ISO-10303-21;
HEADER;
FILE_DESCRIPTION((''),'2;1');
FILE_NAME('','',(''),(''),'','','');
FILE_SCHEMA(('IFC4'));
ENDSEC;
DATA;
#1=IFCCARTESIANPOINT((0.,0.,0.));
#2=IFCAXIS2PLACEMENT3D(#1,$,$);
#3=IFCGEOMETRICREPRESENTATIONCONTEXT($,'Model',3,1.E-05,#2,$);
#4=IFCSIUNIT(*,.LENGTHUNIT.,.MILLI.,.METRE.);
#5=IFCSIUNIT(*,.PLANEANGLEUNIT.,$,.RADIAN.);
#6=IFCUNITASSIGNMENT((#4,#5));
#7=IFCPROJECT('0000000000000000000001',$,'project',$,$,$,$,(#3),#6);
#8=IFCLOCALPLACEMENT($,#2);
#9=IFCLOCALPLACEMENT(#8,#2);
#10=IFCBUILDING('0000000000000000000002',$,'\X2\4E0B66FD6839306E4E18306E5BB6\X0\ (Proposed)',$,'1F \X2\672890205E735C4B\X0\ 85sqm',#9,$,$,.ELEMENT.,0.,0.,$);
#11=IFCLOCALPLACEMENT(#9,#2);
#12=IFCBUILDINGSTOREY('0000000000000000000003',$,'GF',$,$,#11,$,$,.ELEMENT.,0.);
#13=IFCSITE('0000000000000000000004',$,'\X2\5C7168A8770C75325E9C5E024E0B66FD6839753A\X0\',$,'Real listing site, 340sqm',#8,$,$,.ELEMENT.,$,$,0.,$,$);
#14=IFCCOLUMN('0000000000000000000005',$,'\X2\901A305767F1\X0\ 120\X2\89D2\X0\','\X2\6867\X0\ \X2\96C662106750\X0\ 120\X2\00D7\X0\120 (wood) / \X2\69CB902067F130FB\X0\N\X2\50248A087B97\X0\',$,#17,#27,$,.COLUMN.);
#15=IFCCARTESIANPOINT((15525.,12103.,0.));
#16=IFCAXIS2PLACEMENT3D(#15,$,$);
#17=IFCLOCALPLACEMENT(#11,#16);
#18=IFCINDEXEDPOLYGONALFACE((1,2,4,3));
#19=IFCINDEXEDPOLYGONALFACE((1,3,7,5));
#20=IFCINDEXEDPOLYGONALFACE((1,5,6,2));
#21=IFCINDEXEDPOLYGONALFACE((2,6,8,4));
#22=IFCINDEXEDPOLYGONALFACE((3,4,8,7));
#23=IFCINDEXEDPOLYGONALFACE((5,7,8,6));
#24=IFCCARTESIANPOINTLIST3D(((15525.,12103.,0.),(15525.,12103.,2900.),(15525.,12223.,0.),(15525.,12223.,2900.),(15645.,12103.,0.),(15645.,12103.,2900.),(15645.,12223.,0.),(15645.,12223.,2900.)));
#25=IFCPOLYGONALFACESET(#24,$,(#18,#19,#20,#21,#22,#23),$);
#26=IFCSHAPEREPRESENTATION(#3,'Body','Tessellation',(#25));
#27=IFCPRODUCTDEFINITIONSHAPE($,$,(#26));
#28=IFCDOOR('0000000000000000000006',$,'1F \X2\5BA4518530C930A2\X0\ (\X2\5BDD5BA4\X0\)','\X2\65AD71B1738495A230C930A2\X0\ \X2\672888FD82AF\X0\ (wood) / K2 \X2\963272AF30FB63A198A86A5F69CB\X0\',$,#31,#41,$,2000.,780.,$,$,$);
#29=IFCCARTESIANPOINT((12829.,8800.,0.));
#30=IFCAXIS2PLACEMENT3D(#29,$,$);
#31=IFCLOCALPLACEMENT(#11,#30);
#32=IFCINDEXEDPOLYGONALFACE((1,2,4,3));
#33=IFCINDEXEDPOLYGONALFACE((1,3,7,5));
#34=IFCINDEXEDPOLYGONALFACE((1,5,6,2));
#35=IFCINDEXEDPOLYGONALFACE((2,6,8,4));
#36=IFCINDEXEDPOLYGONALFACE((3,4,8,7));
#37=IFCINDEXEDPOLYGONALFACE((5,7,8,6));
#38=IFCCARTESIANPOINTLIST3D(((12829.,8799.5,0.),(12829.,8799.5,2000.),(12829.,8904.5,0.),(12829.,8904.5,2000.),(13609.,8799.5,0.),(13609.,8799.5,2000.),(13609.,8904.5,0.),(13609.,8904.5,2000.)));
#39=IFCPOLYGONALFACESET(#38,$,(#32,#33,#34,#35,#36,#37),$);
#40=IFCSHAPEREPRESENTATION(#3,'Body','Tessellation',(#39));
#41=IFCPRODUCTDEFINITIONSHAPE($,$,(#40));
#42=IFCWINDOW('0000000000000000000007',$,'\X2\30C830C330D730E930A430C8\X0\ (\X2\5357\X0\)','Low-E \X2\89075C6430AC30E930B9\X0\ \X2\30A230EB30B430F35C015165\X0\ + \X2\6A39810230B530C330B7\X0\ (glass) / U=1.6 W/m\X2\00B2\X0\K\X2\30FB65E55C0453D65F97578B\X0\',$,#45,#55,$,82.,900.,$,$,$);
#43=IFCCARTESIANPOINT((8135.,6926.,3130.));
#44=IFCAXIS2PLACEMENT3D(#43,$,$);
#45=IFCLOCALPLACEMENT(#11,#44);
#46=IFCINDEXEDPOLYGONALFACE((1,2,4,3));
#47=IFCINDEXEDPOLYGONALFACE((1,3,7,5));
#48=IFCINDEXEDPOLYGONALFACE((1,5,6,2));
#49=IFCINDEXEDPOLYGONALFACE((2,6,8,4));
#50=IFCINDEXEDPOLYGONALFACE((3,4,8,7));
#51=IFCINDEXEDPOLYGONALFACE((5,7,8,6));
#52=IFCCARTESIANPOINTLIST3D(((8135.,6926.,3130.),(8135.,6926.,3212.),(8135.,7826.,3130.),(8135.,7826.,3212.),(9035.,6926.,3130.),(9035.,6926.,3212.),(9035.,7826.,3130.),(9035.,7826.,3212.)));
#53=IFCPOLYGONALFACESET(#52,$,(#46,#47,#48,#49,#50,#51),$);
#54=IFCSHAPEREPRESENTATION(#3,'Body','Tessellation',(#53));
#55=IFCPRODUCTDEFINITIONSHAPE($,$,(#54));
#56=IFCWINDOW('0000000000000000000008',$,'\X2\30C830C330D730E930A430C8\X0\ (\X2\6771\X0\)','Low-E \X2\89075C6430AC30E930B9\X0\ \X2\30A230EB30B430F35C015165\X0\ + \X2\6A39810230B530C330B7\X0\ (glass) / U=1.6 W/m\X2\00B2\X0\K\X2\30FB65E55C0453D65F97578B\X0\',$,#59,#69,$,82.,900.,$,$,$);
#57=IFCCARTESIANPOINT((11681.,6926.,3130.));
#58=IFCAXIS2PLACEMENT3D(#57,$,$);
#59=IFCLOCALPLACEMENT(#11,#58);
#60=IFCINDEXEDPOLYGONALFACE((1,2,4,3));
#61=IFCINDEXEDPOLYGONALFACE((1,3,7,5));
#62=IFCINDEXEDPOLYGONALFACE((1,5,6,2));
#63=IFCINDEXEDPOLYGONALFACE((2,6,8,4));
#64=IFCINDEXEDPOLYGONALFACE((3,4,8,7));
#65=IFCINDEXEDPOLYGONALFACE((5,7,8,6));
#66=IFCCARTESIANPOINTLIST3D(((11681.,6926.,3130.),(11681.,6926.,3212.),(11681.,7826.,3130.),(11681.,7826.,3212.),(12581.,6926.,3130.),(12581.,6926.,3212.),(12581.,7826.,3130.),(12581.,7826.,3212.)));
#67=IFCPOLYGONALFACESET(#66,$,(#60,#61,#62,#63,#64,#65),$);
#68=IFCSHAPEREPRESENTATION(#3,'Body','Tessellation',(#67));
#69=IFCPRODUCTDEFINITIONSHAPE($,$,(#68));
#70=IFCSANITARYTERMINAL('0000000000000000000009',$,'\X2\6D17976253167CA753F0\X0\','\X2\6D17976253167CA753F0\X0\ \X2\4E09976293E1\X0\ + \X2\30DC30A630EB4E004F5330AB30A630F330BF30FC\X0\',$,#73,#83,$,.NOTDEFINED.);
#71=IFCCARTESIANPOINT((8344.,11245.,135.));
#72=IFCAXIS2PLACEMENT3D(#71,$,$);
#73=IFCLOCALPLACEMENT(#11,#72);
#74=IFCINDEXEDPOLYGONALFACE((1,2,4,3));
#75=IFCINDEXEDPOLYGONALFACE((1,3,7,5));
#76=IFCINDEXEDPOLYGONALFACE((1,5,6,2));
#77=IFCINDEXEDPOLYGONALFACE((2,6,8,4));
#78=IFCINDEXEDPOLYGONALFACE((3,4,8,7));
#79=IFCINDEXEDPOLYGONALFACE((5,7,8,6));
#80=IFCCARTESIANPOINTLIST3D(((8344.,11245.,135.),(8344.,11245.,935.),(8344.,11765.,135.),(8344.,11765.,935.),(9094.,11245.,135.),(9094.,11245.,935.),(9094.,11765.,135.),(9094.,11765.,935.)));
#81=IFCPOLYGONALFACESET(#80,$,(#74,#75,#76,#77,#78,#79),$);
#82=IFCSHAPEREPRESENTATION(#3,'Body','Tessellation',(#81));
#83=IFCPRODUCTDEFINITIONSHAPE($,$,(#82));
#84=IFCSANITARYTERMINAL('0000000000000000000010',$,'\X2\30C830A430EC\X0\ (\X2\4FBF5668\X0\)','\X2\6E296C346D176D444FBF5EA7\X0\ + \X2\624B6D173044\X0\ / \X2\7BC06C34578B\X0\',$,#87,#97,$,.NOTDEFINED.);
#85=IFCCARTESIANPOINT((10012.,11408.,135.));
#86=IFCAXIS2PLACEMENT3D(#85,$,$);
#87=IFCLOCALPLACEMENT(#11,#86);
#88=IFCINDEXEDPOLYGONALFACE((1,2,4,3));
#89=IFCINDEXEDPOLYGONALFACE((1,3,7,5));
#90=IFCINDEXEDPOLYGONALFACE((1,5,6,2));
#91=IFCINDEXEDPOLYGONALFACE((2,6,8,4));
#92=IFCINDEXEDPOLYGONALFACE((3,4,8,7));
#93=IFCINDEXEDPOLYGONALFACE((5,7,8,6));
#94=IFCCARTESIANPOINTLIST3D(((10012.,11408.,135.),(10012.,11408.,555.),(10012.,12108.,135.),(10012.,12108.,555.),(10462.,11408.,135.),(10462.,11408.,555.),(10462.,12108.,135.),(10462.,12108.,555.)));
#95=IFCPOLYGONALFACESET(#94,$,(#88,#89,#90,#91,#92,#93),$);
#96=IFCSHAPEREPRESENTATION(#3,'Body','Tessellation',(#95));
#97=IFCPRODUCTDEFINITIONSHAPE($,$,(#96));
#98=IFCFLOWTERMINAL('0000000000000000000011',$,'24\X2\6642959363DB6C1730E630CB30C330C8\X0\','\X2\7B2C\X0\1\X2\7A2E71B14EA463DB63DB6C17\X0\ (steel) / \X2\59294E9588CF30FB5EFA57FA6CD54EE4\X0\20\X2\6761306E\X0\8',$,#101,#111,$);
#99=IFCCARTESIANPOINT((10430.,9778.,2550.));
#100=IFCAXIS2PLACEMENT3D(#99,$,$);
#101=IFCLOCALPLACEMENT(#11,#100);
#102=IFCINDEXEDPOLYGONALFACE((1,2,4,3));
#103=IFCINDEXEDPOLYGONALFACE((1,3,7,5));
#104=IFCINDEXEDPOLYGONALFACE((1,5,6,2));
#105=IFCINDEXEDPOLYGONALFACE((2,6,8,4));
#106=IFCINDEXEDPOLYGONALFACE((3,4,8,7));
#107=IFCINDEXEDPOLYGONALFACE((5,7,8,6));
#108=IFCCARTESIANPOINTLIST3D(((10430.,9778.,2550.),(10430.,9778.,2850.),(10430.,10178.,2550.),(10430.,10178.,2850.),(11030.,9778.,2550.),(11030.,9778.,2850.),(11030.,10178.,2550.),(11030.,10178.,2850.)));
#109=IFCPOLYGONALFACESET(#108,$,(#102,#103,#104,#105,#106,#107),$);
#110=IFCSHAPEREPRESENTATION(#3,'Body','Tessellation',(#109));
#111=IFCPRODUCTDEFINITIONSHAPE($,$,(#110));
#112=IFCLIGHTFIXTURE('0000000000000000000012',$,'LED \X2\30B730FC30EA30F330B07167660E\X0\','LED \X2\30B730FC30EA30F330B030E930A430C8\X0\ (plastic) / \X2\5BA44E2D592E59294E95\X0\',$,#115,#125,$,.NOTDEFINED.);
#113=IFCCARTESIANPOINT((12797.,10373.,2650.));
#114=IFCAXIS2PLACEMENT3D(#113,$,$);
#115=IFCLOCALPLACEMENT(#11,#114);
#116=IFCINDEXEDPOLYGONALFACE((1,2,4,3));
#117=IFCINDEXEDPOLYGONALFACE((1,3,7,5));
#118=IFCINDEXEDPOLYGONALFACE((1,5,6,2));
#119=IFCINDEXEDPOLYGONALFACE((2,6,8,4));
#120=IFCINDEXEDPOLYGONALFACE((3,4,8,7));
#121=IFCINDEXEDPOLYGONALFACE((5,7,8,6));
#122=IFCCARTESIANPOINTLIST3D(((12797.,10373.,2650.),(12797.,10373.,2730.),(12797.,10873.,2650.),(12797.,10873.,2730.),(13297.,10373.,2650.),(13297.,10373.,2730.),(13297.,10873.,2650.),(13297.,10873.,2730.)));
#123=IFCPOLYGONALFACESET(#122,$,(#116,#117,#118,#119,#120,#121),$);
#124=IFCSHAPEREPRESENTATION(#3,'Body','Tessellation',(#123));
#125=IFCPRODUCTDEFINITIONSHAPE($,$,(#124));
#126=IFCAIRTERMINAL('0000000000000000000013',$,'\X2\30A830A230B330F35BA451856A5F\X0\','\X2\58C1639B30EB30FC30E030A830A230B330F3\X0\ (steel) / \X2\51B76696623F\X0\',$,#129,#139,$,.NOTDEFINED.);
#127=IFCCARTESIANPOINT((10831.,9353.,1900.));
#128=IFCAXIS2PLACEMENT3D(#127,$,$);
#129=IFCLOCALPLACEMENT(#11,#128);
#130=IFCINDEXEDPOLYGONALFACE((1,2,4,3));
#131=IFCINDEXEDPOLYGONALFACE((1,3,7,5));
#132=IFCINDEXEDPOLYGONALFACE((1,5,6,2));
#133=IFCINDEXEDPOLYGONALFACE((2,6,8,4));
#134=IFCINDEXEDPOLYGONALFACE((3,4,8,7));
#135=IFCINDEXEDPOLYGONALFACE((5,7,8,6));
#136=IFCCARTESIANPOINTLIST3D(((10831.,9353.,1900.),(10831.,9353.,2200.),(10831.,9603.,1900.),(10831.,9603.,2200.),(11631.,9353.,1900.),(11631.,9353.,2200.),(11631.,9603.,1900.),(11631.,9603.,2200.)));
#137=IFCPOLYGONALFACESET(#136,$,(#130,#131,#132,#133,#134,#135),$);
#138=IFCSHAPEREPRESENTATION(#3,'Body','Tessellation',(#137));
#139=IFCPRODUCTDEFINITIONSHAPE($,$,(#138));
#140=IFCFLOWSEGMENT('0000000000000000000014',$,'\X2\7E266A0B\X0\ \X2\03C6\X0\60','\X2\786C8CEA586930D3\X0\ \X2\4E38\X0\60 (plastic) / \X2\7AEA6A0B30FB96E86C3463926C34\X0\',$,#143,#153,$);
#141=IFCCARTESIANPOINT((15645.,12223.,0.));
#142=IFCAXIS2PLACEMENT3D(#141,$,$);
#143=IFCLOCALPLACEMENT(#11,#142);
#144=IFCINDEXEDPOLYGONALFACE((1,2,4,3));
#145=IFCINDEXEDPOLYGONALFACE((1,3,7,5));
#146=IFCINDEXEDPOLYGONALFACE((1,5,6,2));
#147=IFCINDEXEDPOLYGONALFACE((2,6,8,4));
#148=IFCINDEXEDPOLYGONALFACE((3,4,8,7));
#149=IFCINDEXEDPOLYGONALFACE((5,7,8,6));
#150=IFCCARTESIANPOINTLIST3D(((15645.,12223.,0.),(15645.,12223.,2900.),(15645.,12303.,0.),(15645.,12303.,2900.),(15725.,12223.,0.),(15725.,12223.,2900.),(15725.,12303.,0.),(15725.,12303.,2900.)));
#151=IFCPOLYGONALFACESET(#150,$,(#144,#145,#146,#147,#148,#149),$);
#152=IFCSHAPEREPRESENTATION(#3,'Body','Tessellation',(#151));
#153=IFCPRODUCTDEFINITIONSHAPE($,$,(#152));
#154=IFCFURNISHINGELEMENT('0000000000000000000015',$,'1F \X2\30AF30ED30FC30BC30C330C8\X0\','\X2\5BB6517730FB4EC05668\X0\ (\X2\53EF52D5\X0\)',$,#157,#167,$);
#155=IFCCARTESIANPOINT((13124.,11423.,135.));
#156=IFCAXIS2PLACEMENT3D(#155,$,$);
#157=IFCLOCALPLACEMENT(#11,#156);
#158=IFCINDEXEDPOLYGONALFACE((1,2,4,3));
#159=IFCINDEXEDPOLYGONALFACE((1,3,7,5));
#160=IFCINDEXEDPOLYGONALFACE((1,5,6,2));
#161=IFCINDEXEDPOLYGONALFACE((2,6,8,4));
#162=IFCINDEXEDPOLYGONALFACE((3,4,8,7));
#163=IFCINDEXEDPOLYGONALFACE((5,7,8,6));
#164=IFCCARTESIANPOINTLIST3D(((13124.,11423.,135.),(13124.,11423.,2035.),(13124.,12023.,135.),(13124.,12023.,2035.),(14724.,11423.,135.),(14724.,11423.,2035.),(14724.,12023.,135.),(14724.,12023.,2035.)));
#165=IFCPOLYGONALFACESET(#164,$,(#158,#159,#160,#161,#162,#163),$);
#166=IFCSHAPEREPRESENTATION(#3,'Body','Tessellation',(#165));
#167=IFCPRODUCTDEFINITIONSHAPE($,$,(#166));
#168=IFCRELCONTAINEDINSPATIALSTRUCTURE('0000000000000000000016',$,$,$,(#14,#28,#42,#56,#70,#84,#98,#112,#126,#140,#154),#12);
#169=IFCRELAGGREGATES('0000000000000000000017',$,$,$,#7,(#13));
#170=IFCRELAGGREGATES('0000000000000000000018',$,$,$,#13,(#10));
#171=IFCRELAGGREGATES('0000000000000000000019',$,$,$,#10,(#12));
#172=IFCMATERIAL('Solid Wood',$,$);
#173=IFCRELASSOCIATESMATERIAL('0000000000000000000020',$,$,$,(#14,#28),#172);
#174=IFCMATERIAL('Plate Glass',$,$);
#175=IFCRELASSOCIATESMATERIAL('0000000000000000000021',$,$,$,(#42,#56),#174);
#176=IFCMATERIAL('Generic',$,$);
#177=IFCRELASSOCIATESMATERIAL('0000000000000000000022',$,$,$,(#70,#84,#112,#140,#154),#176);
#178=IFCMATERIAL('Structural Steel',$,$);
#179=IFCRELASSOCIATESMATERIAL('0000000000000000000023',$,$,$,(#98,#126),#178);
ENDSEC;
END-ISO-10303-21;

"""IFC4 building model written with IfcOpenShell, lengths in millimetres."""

from ifc_helpers import new_model, si_unit, frame, frame_2d, origin, place, context, project, spatial, rectangle, extrude, material, element, save


model = new_model("IFC4")

# Units and contexts
model_context = context("Model", 3, precision=1e-05, world=origin())
ifc_project = project(units=[si_unit("LENGTHUNIT", "METRE", prefix="MILLI"), si_unit("PLANEANGLEUNIT", "RADIAN")], contexts=[model_context])

# Site, building, storey
site_placement = place(None, origin())
site = spatial("IfcSite", under=ifc_project, at=site_placement, Name="山梨県甲府市下曽根町", ObjectType="Real listing site, 340sqm", CompositionType="ELEMENT", RefElevation=0.0)
building_placement = place(site_placement, origin())
building = spatial("IfcBuilding", under=site, at=building_placement, Name="下曽根の丘の家 (Proposed)", ObjectType="1F 木造平屋 85sqm", CompositionType="ELEMENT", ElevationOfRefHeight=0.0, ElevationOfTerrain=0.0)
storey_placement = place(building_placement, origin())
storey = spatial("IfcBuildingStorey", under=building, at=storey_placement, Name="GF", CompositionType="ELEMENT", Elevation=0.0)

# Column
ifc_material_1 = material(Name="Solid Wood")
column_1_placement = place(storey_placement, frame((15525.0, 12103.0, 0.0)))
element("IfcColumn", 1, at=column_1_placement, inside=storey, material=ifc_material_1, Name="通し柱 120角", Description="桧 集成材 120×120 (wood) / 構造柱・N値計算", PredefinedType="COLUMN", context=model_context, shape_type="SweptSolid", body=[
    extrude(rectangle(XDim=120.0, YDim=120.0, at=frame_2d((60.0, 60.0))), frame((15525.0, 12103.0, 0.0)), (0.0, 0.0, 1.0), 2900.0),
])

# Door
door_placement = place(storey_placement, frame((12829.0, 8800.0, 0.0)))
element("IfcDoor", 2, at=door_placement, inside=storey, material=ifc_material_1, Name="1F 室内ドア (寝室)", Description="断熱玄関ドア 木製芯 (wood) / K2 防犯・採風機構", OverallHeight=2000.0, OverallWidth=780.0, context=model_context, shape_type="SweptSolid", body=[
    extrude(rectangle(XDim=780.0, YDim=105.0, at=frame_2d((390.0, 52.0))), frame((12829.0, 8800.0, 0.0)), (0.0, 0.0, 1.0), 2000.0),
])

# Windows
ifc_material_2 = material(Name="Plate Glass")
window_1_placement = place(storey_placement, frame((8135.0, 6926.0, 3130.0)))
element("IfcWindow", 3, at=window_1_placement, inside=storey, material=ifc_material_2, Name="トップライト (南)", Description="Low-E 複層ガラス アルゴン封入 + 樹脂サッシ (glass) / U=1.6 W/m²K・日射取得型", OverallHeight=82.0, OverallWidth=900.0, context=model_context, shape_type="SweptSolid", body=[
    extrude(rectangle(XDim=900.0, YDim=900.0, at=frame_2d((450.0, 450.0))), frame((8135.0, 6926.0, 3130.0)), (0.0, 0.0, 1.0), 82.0),
])
window_2_placement = place(storey_placement, frame((11681.0, 6926.0, 3130.0)))
element("IfcWindow", 4, at=window_2_placement, inside=storey, material=ifc_material_2, Name="トップライト (東)", Description="Low-E 複層ガラス アルゴン封入 + 樹脂サッシ (glass) / U=1.6 W/m²K・日射取得型", OverallHeight=82.0, OverallWidth=900.0, context=model_context, shape_type="SweptSolid", body=[
    extrude(rectangle(XDim=900.0, YDim=900.0, at=frame_2d((450.0, 450.0))), frame((11681.0, 6926.0, 3130.0)), (0.0, 0.0, 1.0), 82.0),
])

# Sanitary terminals
ifc_material_3 = material(Name="Generic")
sanitary_terminal_1_placement = place(storey_placement, frame((8344.0, 11245.0, 135.0)))
element("IfcSanitaryTerminal", 5, at=sanitary_terminal_1_placement, inside=storey, material=ifc_material_3, Name="洗面化粧台", Description="洗面化粧台 三面鏡 + ボウル一体カウンター", PredefinedType="NOTDEFINED", context=model_context, shape_type="SweptSolid", body=[
    extrude(rectangle(XDim=750.0, YDim=520.0, at=frame_2d((375.0, 260.0))), frame((8344.0, 11245.0, 135.0)), (0.0, 0.0, 1.0), 800.0),
])
sanitary_terminal_2_placement = place(storey_placement, frame((10012.0, 11408.0, 135.0)))
element("IfcSanitaryTerminal", 6, at=sanitary_terminal_2_placement, inside=storey, material=ifc_material_3, Name="トイレ (便器)", Description="温水洗浄便座 + 手洗い / 節水型", PredefinedType="NOTDEFINED", context=model_context, shape_type="SweptSolid", body=[
    extrude(rectangle(XDim=450.0, YDim=700.0, at=frame_2d((225.0, 350.0))), frame((10012.0, 11408.0, 135.0)), (0.0, 0.0, 1.0), 420.0),
])

# Flow terminal
ifc_material_4 = material(Name="Structural Steel")
flow_terminal_placement = place(storey_placement, frame((10430.0, 9778.0, 2550.0)))
element("IfcFlowTerminal", 7, at=flow_terminal_placement, inside=storey, material=ifc_material_4, Name="24時間換気ユニット", Description="第1種熱交換換気 (steel) / 天井裏・建基法令20条の8", context=model_context, shape_type="SweptSolid", body=[
    extrude(rectangle(XDim=600.0, YDim=400.0, at=frame_2d((300.0, 200.0))), frame((10430.0, 9778.0, 2550.0)), (0.0, 0.0, 1.0), 300.0),
])

# Light fixture
light_fixture_placement = place(storey_placement, frame((12797.0, 10373.0, 2650.0)))
element("IfcLightFixture", 8, at=light_fixture_placement, inside=storey, material=ifc_material_3, Name="LED シーリング照明", Description="LED シーリングライト (plastic) / 室中央天井", PredefinedType="NOTDEFINED", context=model_context, shape_type="SweptSolid", body=[
    extrude(rectangle(XDim=500.0, YDim=500.0, at=frame_2d((250.0, 250.0))), frame((12797.0, 10373.0, 2650.0)), (0.0, 0.0, 1.0), 80.0),
])

# Air terminal
air_terminal_placement = place(storey_placement, frame((10831.0, 9353.0, 1900.0)))
element("IfcAirTerminal", 9, at=air_terminal_placement, inside=storey, material=ifc_material_4, Name="エアコン室内機", Description="壁掛ルームエアコン (steel) / 冷暖房", PredefinedType="NOTDEFINED", context=model_context, shape_type="SweptSolid", body=[
    extrude(rectangle(XDim=800.0, YDim=250.0, at=frame_2d((400.0, 125.0))), frame((10831.0, 9353.0, 1900.0)), (0.0, 0.0, 1.0), 300.0),
])

# Flow segment
flow_segment_placement = place(storey_placement, frame((15645.0, 12223.0, 0.0)))
element("IfcFlowSegment", 10, at=flow_segment_placement, inside=storey, material=ifc_material_3, Name="縦樋 φ60", Description="硬質塩ビ 丸60 (plastic) / 竪樋・雨水排水", context=model_context, shape_type="SweptSolid", body=[
    extrude(rectangle(XDim=80.0, YDim=80.0, at=frame_2d((40.0, 40.0))), frame((15645.0, 12223.0, 0.0)), (0.0, 0.0, 1.0), 2900.0),
])

# Furnishing element
furnishing_placement = place(storey_placement, frame((13124.0, 11423.0, 135.0)))
element("IfcFurnishingElement", 11, at=furnishing_placement, inside=storey, material=ifc_material_3, Name="1F クローゼット", Description="家具・什器 (可動)", context=model_context, shape_type="SweptSolid", body=[
    extrude(rectangle(XDim=1600.0, YDim=600.0, at=frame_2d((800.0, 300.0))), frame((13124.0, 11423.0, 135.0)), (0.0, 0.0, 1.0), 1900.0),
])

save(model, "model.ifc")
